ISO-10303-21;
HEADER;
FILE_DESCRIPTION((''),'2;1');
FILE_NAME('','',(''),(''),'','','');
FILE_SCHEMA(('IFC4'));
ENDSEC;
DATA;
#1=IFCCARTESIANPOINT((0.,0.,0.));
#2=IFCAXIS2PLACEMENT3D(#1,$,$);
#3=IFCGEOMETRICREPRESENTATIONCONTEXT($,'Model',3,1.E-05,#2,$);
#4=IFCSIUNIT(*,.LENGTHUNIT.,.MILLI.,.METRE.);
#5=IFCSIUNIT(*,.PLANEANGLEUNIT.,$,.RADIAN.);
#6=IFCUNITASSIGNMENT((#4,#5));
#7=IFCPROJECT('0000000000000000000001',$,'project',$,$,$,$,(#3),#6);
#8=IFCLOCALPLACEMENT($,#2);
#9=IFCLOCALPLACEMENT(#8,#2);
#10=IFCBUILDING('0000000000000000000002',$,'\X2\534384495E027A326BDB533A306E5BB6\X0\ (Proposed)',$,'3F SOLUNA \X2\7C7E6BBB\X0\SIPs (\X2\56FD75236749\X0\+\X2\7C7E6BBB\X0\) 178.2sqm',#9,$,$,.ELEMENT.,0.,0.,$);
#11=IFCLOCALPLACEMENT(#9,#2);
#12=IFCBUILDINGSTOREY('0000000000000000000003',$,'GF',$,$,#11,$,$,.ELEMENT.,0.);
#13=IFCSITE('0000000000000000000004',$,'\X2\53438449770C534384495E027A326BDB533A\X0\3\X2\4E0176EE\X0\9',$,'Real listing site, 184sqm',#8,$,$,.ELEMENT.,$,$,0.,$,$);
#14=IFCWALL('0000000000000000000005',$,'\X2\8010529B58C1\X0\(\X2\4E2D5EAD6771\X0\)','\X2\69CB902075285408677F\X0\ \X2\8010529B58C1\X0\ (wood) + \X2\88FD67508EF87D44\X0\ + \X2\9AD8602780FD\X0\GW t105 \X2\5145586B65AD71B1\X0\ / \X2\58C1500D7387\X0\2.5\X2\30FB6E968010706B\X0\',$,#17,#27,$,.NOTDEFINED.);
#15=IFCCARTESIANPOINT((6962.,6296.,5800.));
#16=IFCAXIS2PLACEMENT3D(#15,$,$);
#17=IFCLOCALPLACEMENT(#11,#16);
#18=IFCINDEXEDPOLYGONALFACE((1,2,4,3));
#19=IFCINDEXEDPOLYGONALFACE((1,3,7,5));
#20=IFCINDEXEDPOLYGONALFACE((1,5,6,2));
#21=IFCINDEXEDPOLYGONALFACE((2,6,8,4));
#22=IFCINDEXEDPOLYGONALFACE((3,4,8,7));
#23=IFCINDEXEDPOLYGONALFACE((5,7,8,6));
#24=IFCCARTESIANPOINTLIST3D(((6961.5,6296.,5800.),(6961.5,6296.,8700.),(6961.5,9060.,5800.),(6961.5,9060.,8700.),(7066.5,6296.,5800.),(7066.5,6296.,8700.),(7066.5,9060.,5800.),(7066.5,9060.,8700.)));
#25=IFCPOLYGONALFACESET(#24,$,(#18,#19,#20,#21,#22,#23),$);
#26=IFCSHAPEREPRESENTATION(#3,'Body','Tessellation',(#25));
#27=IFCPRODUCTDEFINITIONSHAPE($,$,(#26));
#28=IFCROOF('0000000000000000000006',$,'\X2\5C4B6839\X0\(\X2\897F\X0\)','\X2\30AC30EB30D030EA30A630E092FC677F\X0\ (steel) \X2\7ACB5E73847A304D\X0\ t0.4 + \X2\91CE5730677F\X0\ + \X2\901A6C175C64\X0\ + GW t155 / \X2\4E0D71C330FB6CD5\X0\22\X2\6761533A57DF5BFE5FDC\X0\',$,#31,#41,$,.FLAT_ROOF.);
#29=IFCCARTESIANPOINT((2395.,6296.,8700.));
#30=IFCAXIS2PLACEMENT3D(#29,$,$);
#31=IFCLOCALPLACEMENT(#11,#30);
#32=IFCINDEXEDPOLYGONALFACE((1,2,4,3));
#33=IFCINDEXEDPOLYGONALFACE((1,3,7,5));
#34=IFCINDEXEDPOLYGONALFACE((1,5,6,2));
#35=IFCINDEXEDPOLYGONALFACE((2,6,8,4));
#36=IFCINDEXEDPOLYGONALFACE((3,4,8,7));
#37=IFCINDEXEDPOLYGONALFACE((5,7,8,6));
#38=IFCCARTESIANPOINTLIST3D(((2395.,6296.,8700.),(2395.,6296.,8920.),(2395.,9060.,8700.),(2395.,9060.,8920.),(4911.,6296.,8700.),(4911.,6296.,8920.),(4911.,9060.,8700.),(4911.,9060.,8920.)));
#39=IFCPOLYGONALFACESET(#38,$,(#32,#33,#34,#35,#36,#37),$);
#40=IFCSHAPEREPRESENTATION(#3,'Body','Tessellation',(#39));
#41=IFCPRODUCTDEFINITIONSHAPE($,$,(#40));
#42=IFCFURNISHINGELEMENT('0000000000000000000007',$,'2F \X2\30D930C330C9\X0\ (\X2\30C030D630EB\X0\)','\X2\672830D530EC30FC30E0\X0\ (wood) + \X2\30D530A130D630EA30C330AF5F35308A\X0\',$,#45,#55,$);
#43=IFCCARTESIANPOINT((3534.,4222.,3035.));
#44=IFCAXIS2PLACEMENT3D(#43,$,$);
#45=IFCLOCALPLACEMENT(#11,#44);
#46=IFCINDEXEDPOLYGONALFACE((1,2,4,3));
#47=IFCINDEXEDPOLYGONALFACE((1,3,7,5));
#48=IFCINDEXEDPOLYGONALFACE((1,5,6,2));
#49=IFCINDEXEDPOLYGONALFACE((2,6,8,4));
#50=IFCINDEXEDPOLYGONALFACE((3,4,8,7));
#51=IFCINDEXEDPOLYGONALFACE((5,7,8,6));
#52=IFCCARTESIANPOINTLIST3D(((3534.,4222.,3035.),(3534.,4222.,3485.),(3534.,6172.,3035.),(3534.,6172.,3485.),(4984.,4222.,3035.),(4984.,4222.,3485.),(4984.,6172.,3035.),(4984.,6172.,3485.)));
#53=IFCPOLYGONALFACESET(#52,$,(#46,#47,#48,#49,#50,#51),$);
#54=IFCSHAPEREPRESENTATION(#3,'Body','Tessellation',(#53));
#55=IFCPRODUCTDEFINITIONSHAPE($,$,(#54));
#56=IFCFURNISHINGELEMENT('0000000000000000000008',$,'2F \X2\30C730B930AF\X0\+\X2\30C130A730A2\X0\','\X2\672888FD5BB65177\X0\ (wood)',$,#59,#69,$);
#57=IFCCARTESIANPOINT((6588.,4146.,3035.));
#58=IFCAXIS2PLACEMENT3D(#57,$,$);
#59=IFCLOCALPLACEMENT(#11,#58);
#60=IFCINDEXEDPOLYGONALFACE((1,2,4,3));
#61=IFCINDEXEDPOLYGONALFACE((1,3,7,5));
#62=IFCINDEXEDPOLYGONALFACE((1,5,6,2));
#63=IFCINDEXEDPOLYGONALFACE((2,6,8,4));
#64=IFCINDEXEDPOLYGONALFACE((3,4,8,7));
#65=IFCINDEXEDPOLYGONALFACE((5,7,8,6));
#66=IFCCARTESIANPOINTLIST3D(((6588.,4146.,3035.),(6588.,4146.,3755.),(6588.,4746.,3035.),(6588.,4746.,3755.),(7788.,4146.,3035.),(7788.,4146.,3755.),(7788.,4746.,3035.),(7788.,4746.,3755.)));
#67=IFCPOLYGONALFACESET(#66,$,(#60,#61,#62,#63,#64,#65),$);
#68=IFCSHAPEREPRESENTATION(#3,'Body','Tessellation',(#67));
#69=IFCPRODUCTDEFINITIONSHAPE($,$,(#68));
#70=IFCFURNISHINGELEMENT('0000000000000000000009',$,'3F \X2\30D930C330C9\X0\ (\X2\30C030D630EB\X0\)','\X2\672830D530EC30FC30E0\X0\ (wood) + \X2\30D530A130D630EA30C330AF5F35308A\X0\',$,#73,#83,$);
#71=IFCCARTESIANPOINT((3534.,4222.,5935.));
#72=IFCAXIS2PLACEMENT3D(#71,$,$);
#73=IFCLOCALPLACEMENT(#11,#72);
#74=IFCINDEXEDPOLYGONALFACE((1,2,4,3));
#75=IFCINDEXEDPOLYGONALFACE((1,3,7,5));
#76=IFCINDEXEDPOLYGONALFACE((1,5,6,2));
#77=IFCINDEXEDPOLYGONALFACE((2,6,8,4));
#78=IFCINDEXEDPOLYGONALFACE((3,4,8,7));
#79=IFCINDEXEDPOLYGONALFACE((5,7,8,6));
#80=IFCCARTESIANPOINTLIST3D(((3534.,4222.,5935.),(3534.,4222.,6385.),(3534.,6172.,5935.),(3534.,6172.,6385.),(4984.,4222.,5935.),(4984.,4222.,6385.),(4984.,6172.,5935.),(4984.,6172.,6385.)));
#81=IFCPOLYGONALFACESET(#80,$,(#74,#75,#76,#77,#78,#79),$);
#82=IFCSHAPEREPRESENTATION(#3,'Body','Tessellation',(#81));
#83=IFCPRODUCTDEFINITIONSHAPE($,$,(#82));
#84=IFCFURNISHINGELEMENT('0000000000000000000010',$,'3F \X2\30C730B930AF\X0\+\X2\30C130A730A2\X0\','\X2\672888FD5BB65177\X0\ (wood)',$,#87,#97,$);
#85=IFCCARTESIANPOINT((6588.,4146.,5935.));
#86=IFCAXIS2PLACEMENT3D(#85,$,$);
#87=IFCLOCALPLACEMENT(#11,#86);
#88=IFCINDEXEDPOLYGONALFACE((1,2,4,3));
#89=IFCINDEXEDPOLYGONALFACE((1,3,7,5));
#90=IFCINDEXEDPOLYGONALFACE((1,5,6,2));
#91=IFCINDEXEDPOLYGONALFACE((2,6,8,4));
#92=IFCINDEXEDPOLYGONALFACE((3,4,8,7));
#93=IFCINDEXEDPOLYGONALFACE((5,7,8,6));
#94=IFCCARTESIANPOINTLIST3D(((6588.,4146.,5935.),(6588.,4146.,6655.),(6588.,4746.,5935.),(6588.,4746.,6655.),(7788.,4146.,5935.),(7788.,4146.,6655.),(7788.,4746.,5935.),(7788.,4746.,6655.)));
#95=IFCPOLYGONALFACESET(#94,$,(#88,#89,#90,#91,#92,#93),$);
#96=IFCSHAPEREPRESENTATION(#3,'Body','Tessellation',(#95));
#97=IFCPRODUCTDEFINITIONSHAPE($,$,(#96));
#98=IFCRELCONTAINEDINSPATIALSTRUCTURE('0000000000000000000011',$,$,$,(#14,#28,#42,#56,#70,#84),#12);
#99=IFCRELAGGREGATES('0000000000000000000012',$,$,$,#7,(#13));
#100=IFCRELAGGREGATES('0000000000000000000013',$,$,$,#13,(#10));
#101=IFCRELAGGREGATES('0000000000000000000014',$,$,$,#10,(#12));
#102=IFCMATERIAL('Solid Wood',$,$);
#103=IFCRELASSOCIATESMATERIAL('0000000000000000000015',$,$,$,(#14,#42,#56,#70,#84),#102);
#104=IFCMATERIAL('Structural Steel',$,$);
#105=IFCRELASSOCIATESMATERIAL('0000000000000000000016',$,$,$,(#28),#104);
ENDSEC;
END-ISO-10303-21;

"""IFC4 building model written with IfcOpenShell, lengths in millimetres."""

from ifc_helpers import new_model, si_unit, frame, frame_2d, origin, place, context, project, spatial, rectangle, extrude, material, element, save


model = new_model("IFC4")

# Units and contexts
model_context = context("Model", 3, precision=1e-05, world=origin())
ifc_project = project(units=[si_unit("LENGTHUNIT", "METRE", prefix="MILLI"), si_unit("PLANEANGLEUNIT", "RADIAN")], contexts=[model_context])

# Site, building, storey
site_placement = place(None, origin())
site = spatial("IfcSite", under=ifc_project, at=site_placement, Name="千葉県千葉市稲毛区3丁目9", ObjectType="Real listing site, 184sqm", CompositionType="ELEMENT", RefElevation=0.0)
building_placement = place(site_placement, origin())
building = spatial("IfcBuilding", under=site, at=building_placement, Name="千葉市稲毛区の家 (Proposed)", ObjectType="3F SOLUNA 籾殻SIPs (国産杉+籾殻) 178.2sqm", CompositionType="ELEMENT", ElevationOfRefHeight=0.0, ElevationOfTerrain=0.0)
storey_placement = place(building_placement, origin())
storey = spatial("IfcBuildingStorey", under=building, at=storey_placement, Name="GF", CompositionType="ELEMENT", Elevation=0.0)

# Shared definitions
ifc_material_1 = material(Name="Solid Wood")

# Wall
wall_1_placement = place(storey_placement, frame((6962.0, 6296.0, 5800.0)))
element("IfcWall", 1, at=wall_1_placement, inside=storey, material=ifc_material_1, Name="耐力壁(中庭東)", Description="構造用合板 耐力壁 (wood) + 製材軸組 + 高性能GW t105 充填断熱 / 壁倍率2.5・準耐火", PredefinedType="NOTDEFINED", context=model_context, shape_type="SweptSolid", body=[
    extrude(rectangle(XDim=105.0, YDim=2764.0, at=frame_2d((52.0, 1382.0))), frame((6962.0, 6296.0, 5800.0)), (0.0, 0.0, 1.0), 2900.0),
])

# Roof
ifc_material_2 = material(Name="Structural Steel")
roof_1_placement = place(storey_placement, frame((2395.0, 6296.0, 8700.0)))
element("IfcRoof", 2, at=roof_1_placement, inside=storey, material=ifc_material_2, Name="屋根(西)", Description="ガルバリウム鋼板 (steel) 立平葺き t0.4 + 野地板 + 通気層 + GW t155 / 不燃・法22条区域対応", PredefinedType="FLAT_ROOF", context=model_context, shape_type="SweptSolid", body=[
    extrude(rectangle(XDim=2516.0, YDim=2764.0, at=frame_2d((1258.0, 1382.0))), frame((2395.0, 6296.0, 8700.0)), (0.0, 0.0, 1.0), 220.0),
])

# Furnishing elements
furnishing_1_placement = place(storey_placement, frame((3534.0, 4222.0, 3035.0)))
element("IfcFurnishingElement", 3, at=furnishing_1_placement, inside=storey, material=ifc_material_1, Name="2F ベッド (ダブル)", Description="木フレーム (wood) + ファブリック張り", context=model_context, shape_type="SweptSolid", body=[
    extrude(rectangle(XDim=1450.0, YDim=1950.0, at=frame_2d((725.0, 975.0))), frame((3534.0, 4222.0, 3035.0)), (0.0, 0.0, 1.0), 450.0),
])
furnishing_2_placement = place(storey_placement, frame((6588.0, 4146.0, 3035.0)))
element("IfcFurnishingElement", 4, at=furnishing_2_placement, inside=storey, material=ifc_material_1, Name="2F デスク+チェア", Description="木製家具 (wood)", context=model_context, shape_type="SweptSolid", body=[
    extrude(rectangle(XDim=1200.0, YDim=600.0, at=frame_2d((600.0, 300.0))), frame((6588.0, 4146.0, 3035.0)), (0.0, 0.0, 1.0), 720.0),
])
furnishing_3_placement = place(storey_placement, frame((3534.0, 4222.0, 5935.0)))
element("IfcFurnishingElement", 5, at=furnishing_3_placement, inside=storey, material=ifc_material_1, Name="3F ベッド (ダブル)", Description="木フレーム (wood) + ファブリック張り", context=model_context, shape_type="SweptSolid", body=[
    extrude(rectangle(XDim=1450.0, YDim=1950.0, at=frame_2d((725.0, 975.0))), frame((3534.0, 4222.0, 5935.0)), (0.0, 0.0, 1.0), 450.0),
])
furnishing_4_placement = place(storey_placement, frame((6588.0, 4146.0, 5935.0)))
element("IfcFurnishingElement", 6, at=furnishing_4_placement, inside=storey, material=ifc_material_1, Name="3F デスク+チェア", Description="木製家具 (wood)", context=model_context, shape_type="SweptSolid", body=[
    extrude(rectangle(XDim=1200.0, YDim=600.0, at=frame_2d((600.0, 300.0))), frame((6588.0, 4146.0, 5935.0)), (0.0, 0.0, 1.0), 720.0),
])

save(model, "model.ifc")
